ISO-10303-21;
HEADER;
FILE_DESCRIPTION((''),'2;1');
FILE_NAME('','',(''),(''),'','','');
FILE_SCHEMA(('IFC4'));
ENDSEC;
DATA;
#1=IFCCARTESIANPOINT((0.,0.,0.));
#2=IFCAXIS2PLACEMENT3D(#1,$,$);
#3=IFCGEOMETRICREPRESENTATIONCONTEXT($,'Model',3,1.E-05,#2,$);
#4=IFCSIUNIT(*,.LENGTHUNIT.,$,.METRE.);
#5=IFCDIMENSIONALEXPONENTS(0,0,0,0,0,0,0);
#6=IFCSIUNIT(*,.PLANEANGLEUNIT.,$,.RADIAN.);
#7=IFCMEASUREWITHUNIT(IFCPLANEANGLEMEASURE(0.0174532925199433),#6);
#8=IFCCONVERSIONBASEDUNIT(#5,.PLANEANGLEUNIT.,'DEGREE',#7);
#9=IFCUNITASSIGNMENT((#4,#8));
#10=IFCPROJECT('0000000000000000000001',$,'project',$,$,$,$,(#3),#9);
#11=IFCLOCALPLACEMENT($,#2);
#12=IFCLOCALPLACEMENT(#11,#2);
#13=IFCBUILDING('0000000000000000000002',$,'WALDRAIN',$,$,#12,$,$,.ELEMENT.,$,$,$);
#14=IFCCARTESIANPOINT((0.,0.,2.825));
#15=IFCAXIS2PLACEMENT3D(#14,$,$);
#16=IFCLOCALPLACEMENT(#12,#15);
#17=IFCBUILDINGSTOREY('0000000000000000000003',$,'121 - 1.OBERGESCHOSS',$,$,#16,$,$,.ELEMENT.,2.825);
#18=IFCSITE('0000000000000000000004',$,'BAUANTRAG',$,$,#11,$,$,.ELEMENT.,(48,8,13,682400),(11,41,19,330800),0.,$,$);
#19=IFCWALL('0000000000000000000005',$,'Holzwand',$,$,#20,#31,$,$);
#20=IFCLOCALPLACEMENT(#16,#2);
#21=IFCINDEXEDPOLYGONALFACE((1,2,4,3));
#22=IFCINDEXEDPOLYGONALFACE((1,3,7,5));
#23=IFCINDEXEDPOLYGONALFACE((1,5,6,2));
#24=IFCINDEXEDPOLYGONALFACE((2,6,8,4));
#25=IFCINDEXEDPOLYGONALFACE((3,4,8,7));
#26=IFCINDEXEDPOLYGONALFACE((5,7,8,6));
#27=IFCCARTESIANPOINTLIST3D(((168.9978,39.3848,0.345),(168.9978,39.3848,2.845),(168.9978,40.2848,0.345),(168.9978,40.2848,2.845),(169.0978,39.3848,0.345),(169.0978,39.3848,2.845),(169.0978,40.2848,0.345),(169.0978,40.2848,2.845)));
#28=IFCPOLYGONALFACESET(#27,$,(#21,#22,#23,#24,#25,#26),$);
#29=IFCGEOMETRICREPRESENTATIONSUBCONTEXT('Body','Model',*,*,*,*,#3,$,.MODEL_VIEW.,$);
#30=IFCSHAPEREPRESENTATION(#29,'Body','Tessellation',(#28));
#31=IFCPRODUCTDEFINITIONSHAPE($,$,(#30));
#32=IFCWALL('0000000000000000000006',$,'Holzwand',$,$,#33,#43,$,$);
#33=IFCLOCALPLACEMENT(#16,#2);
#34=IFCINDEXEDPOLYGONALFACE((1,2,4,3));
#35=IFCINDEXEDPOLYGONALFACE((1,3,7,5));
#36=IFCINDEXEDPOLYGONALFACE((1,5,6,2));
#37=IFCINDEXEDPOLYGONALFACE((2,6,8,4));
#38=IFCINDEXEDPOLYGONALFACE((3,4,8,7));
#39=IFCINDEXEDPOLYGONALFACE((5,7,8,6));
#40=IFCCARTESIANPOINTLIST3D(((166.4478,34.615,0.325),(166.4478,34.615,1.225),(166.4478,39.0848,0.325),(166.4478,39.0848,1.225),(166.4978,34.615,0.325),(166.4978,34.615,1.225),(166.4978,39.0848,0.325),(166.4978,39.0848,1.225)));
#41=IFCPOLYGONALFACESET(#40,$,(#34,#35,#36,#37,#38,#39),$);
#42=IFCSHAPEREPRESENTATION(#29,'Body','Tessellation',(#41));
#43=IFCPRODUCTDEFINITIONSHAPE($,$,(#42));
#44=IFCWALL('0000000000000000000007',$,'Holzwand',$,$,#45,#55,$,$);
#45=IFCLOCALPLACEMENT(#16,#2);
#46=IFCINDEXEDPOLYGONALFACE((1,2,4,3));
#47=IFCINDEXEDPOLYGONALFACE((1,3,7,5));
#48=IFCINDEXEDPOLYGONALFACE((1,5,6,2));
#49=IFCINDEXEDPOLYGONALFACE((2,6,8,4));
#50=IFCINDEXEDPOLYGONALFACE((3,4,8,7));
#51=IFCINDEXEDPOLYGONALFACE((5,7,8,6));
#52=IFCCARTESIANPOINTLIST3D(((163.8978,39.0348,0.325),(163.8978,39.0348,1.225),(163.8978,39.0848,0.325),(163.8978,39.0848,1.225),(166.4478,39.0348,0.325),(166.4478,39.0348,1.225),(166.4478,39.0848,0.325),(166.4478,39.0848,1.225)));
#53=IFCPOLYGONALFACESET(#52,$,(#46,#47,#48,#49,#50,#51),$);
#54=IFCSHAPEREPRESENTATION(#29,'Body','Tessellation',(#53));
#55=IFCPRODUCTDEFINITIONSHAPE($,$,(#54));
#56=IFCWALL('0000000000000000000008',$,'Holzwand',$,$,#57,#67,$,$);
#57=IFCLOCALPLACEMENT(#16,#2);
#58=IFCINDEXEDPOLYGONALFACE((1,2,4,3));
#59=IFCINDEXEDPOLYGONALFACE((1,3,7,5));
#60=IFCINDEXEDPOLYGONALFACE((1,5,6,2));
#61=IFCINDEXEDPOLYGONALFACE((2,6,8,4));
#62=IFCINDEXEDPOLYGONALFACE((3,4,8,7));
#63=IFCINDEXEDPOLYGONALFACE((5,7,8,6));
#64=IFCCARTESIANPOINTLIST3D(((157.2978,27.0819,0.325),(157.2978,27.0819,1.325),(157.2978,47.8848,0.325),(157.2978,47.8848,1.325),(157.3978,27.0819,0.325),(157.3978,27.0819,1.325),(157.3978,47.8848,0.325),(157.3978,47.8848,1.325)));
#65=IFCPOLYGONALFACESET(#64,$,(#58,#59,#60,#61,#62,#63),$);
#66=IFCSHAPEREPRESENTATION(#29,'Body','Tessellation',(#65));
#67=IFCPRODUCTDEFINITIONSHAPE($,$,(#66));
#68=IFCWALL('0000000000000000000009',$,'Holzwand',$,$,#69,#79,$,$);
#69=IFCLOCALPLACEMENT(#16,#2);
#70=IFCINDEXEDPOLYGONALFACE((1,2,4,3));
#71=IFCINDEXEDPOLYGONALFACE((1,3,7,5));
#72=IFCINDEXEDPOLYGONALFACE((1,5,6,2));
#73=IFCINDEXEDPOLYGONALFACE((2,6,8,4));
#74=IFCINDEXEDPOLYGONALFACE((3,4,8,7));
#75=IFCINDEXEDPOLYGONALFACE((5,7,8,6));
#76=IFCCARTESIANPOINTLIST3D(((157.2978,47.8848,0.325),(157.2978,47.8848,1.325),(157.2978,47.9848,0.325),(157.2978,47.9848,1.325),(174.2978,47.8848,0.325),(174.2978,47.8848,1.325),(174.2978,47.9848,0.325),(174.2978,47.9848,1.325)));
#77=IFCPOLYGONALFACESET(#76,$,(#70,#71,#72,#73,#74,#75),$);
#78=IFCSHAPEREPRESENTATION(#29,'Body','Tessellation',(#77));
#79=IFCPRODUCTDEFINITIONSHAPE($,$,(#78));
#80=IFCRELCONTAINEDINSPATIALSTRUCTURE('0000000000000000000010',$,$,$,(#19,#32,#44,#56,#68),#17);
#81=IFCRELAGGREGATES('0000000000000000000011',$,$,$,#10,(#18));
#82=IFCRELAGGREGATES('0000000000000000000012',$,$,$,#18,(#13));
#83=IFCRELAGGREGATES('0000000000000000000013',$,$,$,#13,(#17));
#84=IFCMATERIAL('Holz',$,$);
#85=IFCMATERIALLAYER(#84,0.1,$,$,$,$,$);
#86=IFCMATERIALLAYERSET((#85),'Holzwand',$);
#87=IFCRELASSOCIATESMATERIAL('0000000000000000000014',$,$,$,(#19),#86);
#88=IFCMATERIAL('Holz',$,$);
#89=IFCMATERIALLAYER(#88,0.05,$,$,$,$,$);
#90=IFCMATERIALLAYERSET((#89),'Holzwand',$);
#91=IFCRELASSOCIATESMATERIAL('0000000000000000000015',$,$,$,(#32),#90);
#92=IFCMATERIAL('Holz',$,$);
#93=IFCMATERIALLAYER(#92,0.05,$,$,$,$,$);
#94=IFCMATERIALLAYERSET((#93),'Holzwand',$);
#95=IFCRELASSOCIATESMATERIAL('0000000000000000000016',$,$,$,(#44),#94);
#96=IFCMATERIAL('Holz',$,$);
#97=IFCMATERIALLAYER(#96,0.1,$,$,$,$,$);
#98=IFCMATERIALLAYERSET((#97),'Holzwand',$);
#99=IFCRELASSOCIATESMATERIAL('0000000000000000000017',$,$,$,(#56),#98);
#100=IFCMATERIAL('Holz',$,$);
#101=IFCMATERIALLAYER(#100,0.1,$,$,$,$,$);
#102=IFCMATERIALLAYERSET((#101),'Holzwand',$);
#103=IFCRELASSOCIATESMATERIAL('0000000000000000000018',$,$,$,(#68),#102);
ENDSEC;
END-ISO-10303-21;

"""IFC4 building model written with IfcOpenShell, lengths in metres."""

from ifc_helpers import new_model, entity, si_unit, converted_unit, frame, frame_2d, origin, origin_with_axes, place, context, subcontext, project, spatial, rectangle, extrude, material, layer, layer_set, layer_usage, element, save


model = new_model("IFC4")

# Units and contexts
model_context = context("Model", 3, precision=1e-05, world=origin())
body_context = subcontext(model_context, "Body", "Model", "MODEL_VIEW")
ifc_project = project(units=[si_unit("LENGTHUNIT", "METRE"), converted_unit("PLANEANGLEUNIT", "DEGREE", entity("IfcPlaneAngleMeasure", 0.0174532925199433), si_unit("PLANEANGLEUNIT", "RADIAN"), dimensions=[0, 0, 0, 0, 0, 0, 0])], contexts=[model_context])

# Site, building, storey
site_placement = place(None, origin())
site = spatial("IfcSite", under=ifc_project, at=site_placement, Name="BAUANTRAG", CompositionType="ELEMENT", RefLatitude=(48, 8, 13, 682400), RefLongitude=(11, 41, 19, 330800), RefElevation=0.0)
building_placement = place(site_placement, origin())
building = spatial("IfcBuilding", under=site, at=building_placement, Name="WALDRAIN", CompositionType="ELEMENT")
storey_placement = place(building_placement, frame((0.0, 0.0, 2.825)))
storey = spatial("IfcBuildingStorey", under=building, at=storey_placement, Name="121 - 1.OBERGESCHOSS", CompositionType="ELEMENT", Elevation=2.825)

# Walls
ifc_material_1 = material(Name="Holz")
ifc_layer_1 = layer(ifc_material_1, 0.1)
ifc_layer_set_1 = layer_set([ifc_layer_1], Name="Holzwand")
ifc_layer_usage_1 = layer_usage(ifc_layer_set_1, "AXIS2", "POSITIVE", 0.0)
wall_1_placement = place(storey_placement, frame((168.9978, 40.2848, 0.345), z_axis=(0.0, 0.0, 1.0), x_axis=(0.0, -1.0, 0.0)))
element("IfcWall", 1, at=wall_1_placement, inside=storey, material=ifc_layer_usage_1, Name="Holzwand", context=body_context, shape_type="SweptSolid", body=[
    extrude(rectangle(XDim=0.9, YDim=0.1, at=frame_2d((0.45, 0.05), x_axis=(1.0, 0.0))), origin_with_axes(), (0.0, 0.0, 1.0), 2.5),
])
ifc_material_2 = material(Name="Holz")
ifc_layer_2 = layer(ifc_material_2, 0.05)
ifc_layer_set_2 = layer_set([ifc_layer_2], Name="Holzwand")
ifc_layer_usage_2 = layer_usage(ifc_layer_set_2, "AXIS2", "POSITIVE", 0.0)
wall_2_placement = place(storey_placement, frame((166.4478, 39.0848, 0.325), z_axis=(0.0, 0.0, 1.0), x_axis=(0.0, -1.0, 0.0)))
element("IfcWall", 2, at=wall_2_placement, inside=storey, material=ifc_layer_usage_2, Name="Holzwand", context=body_context, shape_type="SweptSolid", body=[
    extrude(rectangle(XDim=4.4698, YDim=0.05, at=frame_2d((2.2349, 0.025), x_axis=(1.0, 0.0))), origin_with_axes(), (0.0, 0.0, 1.0), 0.9),
])
ifc_material_3 = material(Name="Holz")
ifc_layer_3 = layer(ifc_material_3, 0.05)
ifc_layer_set_3 = layer_set([ifc_layer_3], Name="Holzwand")
ifc_layer_usage_3 = layer_usage(ifc_layer_set_3, "AXIS2", "POSITIVE", 0.0)
wall_3_placement = place(storey_placement, frame((163.8978, 39.0348, 0.325)))
element("IfcWall", 3, at=wall_3_placement, inside=storey, material=ifc_layer_usage_3, Name="Holzwand", context=body_context, shape_type="SweptSolid", body=[
    extrude(rectangle(XDim=2.55, YDim=0.05, at=frame_2d((1.275, 0.025), x_axis=(1.0, 0.0))), origin_with_axes(), (0.0, 0.0, 1.0), 0.9),
])
ifc_material_4 = material(Name="Holz")
ifc_layer_4 = layer(ifc_material_4, 0.1)
ifc_layer_set_4 = layer_set([ifc_layer_4], Name="Holzwand")
ifc_layer_usage_4 = layer_usage(ifc_layer_set_4, "AXIS2", "POSITIVE", 0.0)
wall_4_placement = place(storey_placement, frame((157.2978, 47.8848, 0.325), z_axis=(0.0, 0.0, 1.0), x_axis=(0.0, -1.0, 0.0)))
element("IfcWall", 4, at=wall_4_placement, inside=storey, material=ifc_layer_usage_4, Name="Holzwand", context=body_context, shape_type="SweptSolid", body=[
    extrude(rectangle(XDim=20.8029, YDim=0.1, at=frame_2d((10.4014, 0.05), x_axis=(1.0, 0.0))), origin_with_axes(), (0.0, 0.0, 1.0), 1.0),
])
ifc_material_5 = material(Name="Holz")
ifc_layer_5 = layer(ifc_material_5, 0.1)
ifc_layer_set_5 = layer_set([ifc_layer_5], Name="Holzwand")
ifc_layer_usage_5 = layer_usage(ifc_layer_set_5, "AXIS2", "POSITIVE", 0.0)
wall_5_placement = place(storey_placement, frame((174.2978, 47.9848, 0.325), z_axis=(0.0, 0.0, 1.0), x_axis=(-1.0, 0.0, 0.0)))
element("IfcWall", 5, at=wall_5_placement, inside=storey, material=ifc_layer_usage_5, Name="Holzwand", context=body_context, shape_type="SweptSolid", body=[
    extrude(rectangle(XDim=17.0, YDim=0.1, at=frame_2d((8.5, 0.05), x_axis=(1.0, 0.0))), origin_with_axes(), (0.0, 0.0, 1.0), 1.0),
])

save(model, "model.ifc")
